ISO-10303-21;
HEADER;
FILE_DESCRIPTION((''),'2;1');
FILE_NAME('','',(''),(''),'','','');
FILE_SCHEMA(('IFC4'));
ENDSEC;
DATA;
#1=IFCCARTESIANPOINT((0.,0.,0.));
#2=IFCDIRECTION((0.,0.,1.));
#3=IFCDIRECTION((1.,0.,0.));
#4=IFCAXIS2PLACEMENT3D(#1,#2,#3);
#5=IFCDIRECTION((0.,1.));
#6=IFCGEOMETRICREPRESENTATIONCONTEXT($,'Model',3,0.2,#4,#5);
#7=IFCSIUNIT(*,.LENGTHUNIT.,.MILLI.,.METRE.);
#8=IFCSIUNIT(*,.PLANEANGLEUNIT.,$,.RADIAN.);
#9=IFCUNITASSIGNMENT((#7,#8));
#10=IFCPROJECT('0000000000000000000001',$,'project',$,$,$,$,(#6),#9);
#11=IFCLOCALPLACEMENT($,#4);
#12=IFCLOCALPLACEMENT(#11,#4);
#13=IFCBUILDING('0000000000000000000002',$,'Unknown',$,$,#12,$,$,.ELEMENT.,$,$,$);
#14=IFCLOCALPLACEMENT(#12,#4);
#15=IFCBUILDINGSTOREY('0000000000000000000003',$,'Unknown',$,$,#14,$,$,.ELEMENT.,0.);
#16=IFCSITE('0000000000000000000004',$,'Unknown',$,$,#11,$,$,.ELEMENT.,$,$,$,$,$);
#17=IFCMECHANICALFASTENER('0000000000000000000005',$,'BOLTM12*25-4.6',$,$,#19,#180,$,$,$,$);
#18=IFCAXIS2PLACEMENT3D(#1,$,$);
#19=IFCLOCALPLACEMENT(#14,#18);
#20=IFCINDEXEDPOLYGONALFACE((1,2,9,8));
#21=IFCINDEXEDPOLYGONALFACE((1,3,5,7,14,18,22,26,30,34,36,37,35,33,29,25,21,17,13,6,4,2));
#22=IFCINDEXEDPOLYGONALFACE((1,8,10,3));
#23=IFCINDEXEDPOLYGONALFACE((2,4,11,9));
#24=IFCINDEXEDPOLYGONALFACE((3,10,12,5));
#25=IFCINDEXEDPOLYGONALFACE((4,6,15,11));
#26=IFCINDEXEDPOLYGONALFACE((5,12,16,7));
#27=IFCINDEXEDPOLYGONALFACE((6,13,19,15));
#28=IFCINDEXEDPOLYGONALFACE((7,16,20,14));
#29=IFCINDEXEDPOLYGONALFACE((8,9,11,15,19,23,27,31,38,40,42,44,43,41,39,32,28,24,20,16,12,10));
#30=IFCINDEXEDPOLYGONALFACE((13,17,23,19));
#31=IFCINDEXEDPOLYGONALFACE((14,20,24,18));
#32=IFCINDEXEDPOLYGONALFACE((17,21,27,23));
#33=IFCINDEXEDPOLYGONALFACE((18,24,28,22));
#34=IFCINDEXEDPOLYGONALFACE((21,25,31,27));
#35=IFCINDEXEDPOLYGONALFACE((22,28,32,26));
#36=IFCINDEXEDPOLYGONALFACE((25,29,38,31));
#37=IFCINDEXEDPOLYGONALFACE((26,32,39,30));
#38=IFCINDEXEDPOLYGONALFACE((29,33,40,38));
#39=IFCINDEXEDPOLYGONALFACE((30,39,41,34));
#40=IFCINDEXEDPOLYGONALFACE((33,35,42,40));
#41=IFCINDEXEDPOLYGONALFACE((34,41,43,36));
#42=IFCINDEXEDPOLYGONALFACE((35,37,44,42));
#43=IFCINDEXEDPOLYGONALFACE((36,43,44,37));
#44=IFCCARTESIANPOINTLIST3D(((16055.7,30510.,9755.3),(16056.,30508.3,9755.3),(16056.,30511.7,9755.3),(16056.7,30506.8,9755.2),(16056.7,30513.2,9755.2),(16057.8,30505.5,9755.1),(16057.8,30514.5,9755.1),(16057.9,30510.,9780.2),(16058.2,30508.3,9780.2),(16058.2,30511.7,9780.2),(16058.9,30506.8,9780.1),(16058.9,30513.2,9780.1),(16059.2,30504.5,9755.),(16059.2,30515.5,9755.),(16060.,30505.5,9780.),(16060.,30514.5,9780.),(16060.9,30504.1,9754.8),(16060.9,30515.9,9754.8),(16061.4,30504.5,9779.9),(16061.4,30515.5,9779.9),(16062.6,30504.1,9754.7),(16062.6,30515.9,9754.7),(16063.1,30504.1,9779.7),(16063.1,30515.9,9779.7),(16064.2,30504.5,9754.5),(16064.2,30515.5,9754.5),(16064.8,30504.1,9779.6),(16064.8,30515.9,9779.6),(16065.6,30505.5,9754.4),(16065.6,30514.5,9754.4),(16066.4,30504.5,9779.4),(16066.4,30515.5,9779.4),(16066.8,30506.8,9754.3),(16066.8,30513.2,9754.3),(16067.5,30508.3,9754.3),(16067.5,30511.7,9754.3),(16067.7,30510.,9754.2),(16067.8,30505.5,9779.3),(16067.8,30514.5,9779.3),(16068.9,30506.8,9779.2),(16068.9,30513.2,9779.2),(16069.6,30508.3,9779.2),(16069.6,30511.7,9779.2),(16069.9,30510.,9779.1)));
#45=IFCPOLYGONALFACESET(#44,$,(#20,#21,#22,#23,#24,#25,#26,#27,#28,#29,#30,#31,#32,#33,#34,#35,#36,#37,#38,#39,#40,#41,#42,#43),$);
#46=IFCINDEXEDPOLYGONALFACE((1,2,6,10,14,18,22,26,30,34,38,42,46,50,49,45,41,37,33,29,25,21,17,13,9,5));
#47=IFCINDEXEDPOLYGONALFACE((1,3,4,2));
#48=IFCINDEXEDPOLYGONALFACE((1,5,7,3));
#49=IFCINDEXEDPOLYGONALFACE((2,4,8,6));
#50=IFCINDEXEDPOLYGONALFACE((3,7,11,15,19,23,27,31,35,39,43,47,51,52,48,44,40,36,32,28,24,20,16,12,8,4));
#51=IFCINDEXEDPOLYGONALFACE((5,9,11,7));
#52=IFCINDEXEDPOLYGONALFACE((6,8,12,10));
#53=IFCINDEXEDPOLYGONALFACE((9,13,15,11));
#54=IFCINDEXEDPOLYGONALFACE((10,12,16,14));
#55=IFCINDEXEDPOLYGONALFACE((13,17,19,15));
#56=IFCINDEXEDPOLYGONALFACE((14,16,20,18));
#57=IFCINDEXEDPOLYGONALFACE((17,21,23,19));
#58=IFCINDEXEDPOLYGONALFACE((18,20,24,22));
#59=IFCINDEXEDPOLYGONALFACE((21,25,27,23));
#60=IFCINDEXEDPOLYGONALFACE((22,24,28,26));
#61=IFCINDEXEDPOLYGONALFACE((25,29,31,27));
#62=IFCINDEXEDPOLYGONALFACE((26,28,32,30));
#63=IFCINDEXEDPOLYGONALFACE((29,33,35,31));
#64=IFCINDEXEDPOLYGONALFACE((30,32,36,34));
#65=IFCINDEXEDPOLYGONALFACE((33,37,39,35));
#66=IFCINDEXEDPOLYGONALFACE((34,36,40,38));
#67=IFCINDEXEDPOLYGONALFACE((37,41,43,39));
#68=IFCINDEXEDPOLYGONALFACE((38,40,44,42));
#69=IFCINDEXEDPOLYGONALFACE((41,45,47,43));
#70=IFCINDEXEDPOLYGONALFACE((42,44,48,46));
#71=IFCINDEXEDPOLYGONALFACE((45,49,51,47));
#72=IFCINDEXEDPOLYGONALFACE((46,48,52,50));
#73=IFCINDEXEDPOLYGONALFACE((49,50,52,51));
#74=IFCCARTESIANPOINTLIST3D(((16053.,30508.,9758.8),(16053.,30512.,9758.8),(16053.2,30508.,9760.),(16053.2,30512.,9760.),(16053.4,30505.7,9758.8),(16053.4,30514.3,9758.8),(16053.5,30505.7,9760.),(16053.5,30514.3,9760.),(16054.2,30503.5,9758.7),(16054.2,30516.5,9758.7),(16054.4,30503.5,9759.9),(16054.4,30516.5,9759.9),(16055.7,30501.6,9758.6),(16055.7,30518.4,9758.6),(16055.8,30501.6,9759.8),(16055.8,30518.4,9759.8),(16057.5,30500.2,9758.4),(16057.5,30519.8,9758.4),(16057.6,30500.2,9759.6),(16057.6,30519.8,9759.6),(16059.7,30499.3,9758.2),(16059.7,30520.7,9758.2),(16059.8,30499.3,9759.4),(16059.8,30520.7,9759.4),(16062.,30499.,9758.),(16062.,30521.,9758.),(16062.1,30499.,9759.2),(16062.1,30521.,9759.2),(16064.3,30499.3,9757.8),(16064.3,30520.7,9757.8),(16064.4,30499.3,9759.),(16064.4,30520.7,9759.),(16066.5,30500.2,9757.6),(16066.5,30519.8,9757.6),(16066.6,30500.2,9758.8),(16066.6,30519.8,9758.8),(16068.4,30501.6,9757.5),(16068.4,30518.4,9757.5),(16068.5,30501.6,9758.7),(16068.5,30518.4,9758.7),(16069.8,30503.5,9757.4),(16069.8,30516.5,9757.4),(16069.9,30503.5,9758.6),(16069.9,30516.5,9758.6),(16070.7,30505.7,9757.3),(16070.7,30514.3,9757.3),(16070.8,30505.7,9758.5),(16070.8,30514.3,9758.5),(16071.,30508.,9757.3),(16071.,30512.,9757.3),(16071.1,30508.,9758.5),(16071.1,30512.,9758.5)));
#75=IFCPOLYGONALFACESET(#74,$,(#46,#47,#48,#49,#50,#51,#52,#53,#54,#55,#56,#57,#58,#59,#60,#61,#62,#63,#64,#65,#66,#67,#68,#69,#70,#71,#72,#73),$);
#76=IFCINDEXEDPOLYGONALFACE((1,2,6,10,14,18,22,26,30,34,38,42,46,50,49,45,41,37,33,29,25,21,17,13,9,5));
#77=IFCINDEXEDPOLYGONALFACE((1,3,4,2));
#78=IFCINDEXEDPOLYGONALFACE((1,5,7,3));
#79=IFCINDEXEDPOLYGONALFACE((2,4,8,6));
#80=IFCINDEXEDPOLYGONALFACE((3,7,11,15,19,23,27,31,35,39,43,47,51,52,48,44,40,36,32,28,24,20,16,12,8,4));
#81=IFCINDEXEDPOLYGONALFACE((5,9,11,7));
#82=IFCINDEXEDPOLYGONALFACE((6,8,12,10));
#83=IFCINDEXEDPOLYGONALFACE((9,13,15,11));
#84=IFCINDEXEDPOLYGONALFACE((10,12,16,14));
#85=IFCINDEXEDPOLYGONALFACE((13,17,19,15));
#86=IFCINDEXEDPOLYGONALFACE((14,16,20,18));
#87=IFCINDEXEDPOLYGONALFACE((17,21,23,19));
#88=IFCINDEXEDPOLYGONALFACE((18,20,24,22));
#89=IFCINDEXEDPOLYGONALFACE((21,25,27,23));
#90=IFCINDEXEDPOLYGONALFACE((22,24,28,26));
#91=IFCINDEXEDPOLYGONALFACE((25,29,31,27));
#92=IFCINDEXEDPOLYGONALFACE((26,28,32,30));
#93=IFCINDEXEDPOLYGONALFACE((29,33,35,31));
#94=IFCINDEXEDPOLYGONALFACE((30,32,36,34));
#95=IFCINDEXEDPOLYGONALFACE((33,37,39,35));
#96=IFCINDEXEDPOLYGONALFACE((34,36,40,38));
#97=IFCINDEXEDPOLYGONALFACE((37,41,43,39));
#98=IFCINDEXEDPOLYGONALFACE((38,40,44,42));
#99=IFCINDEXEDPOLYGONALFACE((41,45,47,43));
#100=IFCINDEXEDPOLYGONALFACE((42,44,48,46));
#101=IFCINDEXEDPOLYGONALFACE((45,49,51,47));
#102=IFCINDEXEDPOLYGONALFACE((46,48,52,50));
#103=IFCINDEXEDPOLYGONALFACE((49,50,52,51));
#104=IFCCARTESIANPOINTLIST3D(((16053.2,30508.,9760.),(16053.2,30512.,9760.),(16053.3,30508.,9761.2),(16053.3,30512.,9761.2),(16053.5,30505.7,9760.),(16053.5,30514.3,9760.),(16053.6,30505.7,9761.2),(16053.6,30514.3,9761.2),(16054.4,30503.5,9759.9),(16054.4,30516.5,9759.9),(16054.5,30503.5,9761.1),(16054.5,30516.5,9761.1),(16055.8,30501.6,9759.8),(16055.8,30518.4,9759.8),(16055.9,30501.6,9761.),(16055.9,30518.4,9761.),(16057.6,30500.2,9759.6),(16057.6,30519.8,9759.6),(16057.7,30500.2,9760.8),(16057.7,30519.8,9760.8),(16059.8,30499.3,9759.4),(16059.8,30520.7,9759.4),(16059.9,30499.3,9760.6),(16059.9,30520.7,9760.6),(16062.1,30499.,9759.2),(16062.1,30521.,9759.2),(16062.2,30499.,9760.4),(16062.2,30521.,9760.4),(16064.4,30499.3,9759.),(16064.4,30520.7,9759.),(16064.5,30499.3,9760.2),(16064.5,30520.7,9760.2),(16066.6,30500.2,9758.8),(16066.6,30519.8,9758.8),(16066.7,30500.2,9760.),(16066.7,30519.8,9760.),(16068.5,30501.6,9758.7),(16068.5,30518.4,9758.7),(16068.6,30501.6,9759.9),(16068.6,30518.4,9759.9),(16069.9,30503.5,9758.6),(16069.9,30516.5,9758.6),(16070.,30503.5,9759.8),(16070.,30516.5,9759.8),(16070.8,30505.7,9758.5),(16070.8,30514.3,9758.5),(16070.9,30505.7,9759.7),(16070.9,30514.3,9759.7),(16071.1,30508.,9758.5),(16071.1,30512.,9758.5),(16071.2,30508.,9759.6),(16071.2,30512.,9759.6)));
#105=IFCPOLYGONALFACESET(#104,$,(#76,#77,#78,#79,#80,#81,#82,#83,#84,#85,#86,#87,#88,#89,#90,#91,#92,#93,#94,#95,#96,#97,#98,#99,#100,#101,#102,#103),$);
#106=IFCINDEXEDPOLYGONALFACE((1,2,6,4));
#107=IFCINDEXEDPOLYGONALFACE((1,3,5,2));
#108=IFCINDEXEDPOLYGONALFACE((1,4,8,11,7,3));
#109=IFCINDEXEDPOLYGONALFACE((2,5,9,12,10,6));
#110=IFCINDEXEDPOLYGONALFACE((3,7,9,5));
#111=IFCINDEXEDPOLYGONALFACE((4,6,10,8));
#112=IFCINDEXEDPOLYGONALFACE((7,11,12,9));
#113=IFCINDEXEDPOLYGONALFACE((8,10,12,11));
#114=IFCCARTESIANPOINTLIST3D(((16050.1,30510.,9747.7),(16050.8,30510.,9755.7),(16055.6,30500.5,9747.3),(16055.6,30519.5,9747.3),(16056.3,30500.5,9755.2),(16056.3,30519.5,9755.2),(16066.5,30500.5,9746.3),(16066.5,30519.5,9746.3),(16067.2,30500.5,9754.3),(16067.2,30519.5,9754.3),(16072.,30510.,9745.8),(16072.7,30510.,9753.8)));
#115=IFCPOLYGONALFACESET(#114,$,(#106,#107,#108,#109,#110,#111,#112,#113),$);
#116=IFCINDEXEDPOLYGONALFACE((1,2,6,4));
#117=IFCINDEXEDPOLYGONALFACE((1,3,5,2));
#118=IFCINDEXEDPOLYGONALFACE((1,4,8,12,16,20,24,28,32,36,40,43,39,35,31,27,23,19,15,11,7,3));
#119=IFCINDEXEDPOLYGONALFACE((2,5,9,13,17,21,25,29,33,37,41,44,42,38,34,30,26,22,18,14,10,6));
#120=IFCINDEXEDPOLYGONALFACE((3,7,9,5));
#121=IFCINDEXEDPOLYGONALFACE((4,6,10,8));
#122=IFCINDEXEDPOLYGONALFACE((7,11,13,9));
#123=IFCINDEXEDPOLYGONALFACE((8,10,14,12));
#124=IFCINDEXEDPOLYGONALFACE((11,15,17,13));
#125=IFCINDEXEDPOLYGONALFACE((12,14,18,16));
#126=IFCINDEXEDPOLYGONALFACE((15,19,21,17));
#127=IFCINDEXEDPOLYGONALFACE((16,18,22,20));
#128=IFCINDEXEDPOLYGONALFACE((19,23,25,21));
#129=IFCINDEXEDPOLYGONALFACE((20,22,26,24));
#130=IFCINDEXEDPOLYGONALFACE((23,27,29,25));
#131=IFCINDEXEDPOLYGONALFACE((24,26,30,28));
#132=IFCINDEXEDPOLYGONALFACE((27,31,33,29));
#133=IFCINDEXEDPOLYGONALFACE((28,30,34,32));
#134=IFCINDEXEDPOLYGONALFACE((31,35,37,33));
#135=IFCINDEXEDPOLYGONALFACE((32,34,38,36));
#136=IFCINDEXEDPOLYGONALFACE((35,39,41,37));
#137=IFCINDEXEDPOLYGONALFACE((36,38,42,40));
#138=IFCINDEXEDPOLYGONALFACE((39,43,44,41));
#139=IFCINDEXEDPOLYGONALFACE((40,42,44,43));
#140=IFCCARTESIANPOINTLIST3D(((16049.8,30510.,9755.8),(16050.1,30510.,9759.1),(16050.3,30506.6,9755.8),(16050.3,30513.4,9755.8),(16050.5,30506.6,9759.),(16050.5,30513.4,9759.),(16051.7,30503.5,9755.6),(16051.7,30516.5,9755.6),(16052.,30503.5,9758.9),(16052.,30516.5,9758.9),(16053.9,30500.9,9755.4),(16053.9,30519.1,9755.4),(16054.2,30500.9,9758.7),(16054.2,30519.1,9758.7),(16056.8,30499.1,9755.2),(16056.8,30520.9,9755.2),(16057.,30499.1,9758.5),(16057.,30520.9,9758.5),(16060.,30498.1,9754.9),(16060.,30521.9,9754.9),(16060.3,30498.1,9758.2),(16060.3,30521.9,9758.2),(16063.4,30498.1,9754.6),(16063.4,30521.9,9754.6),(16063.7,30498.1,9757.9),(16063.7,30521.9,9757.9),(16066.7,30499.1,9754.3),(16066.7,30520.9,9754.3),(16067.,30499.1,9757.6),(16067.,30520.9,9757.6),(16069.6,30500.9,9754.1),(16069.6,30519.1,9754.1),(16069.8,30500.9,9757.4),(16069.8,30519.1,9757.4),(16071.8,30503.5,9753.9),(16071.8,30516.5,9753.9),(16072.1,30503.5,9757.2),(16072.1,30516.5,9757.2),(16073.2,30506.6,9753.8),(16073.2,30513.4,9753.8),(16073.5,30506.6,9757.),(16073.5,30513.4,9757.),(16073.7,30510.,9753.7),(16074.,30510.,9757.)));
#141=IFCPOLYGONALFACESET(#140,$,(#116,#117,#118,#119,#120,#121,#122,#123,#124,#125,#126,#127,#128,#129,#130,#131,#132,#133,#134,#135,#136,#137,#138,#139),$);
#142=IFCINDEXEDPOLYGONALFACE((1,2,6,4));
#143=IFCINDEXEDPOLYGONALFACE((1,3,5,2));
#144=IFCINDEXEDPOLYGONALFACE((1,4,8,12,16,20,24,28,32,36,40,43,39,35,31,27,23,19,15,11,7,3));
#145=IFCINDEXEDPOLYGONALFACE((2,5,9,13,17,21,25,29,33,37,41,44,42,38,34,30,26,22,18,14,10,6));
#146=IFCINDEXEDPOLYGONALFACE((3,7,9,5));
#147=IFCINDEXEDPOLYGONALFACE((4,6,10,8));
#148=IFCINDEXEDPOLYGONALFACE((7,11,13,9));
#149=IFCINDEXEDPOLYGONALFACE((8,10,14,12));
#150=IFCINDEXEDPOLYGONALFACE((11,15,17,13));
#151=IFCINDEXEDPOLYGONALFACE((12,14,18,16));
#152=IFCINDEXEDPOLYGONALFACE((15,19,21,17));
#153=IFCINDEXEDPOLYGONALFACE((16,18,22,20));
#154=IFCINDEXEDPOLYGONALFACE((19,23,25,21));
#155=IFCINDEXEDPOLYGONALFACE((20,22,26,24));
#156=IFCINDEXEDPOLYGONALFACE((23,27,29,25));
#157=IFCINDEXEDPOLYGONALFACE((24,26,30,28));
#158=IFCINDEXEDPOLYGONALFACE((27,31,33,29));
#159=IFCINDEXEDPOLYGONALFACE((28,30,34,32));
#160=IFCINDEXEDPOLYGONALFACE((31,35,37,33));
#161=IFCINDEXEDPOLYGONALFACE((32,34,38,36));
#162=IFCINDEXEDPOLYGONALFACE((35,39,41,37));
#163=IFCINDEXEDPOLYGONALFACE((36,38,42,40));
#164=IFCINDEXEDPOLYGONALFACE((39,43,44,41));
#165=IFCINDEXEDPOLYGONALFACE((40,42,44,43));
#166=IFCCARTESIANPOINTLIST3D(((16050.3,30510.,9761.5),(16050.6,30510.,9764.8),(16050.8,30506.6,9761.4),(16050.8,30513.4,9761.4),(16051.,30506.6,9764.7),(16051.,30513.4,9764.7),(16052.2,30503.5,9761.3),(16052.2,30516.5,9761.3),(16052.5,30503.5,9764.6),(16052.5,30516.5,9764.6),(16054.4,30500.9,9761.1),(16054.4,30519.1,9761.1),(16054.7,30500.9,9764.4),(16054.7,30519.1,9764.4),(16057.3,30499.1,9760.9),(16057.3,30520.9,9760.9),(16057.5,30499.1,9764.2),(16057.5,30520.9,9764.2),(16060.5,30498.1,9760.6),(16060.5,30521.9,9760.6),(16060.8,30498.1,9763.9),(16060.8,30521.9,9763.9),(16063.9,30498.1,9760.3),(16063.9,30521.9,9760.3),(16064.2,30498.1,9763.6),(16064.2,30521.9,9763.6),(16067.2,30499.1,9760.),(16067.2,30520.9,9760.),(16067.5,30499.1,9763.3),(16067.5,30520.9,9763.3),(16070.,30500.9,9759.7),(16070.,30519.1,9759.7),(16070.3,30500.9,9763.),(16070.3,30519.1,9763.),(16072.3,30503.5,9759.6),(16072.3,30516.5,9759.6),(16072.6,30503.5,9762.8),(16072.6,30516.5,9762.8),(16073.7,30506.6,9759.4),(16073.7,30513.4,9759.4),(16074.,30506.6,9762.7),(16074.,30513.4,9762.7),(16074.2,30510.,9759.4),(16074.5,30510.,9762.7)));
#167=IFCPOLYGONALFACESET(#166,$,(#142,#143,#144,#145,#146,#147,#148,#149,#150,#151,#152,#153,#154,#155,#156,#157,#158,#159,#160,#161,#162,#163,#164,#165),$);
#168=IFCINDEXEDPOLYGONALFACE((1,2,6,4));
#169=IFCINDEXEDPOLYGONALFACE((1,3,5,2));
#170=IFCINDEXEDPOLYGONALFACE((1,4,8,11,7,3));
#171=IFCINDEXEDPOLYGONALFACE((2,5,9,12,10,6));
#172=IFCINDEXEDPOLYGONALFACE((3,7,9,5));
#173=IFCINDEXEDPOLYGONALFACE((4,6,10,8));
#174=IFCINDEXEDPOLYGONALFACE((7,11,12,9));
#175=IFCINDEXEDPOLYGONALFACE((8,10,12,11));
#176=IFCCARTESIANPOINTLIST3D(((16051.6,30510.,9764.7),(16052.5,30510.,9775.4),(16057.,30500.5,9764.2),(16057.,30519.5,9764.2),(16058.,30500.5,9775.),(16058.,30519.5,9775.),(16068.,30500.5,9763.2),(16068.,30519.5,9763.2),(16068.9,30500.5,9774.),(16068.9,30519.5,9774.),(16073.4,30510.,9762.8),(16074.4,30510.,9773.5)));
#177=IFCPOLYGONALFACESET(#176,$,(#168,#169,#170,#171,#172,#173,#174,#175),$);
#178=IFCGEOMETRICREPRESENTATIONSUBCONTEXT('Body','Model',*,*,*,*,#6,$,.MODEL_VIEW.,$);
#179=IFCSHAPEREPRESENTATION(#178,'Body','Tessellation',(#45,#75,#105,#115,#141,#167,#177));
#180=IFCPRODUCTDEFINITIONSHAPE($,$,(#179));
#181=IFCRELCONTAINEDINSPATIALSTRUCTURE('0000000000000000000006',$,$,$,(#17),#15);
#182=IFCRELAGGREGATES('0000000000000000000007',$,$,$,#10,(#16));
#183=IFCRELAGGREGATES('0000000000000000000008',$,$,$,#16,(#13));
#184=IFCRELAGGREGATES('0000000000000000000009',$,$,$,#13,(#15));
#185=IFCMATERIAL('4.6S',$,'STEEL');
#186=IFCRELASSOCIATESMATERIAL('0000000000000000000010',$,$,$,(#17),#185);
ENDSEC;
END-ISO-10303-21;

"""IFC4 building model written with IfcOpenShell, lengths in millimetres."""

from ifc_helpers import new_model, si_unit, direction, frame, origin_with_axes, place, context, subcontext, project, spatial, line, arc, indexed_curve, outline, extrude, source, transform, mapped, material, element, save


model = new_model("IFC4")

# Units and contexts
model_context = context("Model", 3, precision=0.2, world=origin_with_axes(), true_north=direction((0.0, 1.0)))
body_context = subcontext(model_context, "Body", "Model", "MODEL_VIEW")
ifc_project = project(units=[si_unit("LENGTHUNIT", "METRE", prefix="MILLI"), si_unit("PLANEANGLEUNIT", "RADIAN")], contexts=[model_context])

# Site, building, storey
site_placement = place(None, origin_with_axes())
site = spatial("IfcSite", under=ifc_project, at=site_placement, Name="Unknown", CompositionType="ELEMENT")
building_placement = place(site_placement, origin_with_axes())
building = spatial("IfcBuilding", under=site, at=building_placement, Name="Unknown", CompositionType="ELEMENT")
storey_placement = place(building_placement, origin_with_axes())
storey = spatial("IfcBuildingStorey", under=building, at=storey_placement, Name="Unknown", CompositionType="ELEMENT", Elevation=0.0)

# Mechanical fastener
ifc_material_1 = material(Name="4.6S", Category="STEEL")
shared_shape_1 = source(origin_with_axes(), body_context, "Body", "SweptSolid", [
    extrude(outline(indexed_curve([(6.0, 0.0), (0.0, 6.0), (-6.0, 0.0), (0.0, -6.0)], segments=[arc(1, 2, 3), arc(3, 4, 1)])), frame((0.0, 0.0, 4.8), z_axis=(0.0, 0.0, -1.0), x_axis=(0.0, 1.0, 0.0)), (0.0, 0.0, 1.0), 25.0),
    extrude(outline(indexed_curve([(0.0, 11.0), (6.4, 8.4), (9.0, 2.0), (9.0, -2.0), (6.4, -8.4), (0.0, -11.0), (-0.8, -11.0), (-9.0, -2.0), (-9.0, 2.0), (-6.4, 8.4)], segments=[arc(1, 2, 3), line(3, 4), arc(4, 5, 6), arc(6, 7, 8), line(8, 9), arc(9, 10, 1)])), frame((0.0, 0.0, 1.5), z_axis=(0.0, 0.0, -1.0), x_axis=(0.0, 1.0, 0.0)), (0.0, 0.0, 1.0), 1.2),
    extrude(outline(indexed_curve([(0.0, 11.0), (6.4, 8.4), (9.0, 2.0), (9.0, -2.0), (6.4, -8.4), (0.0, -11.0), (-0.8, -11.0), (-9.0, -2.0), (-9.0, 2.0), (-6.4, 8.4)], segments=[arc(1, 2, 3), line(3, 4), arc(4, 5, 6), arc(6, 7, 8), line(8, 9), arc(9, 10, 1)])), frame((0.0, 0.0, 0.3), z_axis=(0.0, 0.0, -1.0), x_axis=(0.0, 1.0, 0.0)), (0.0, 0.0, 1.0), 1.2),
    extrude(outline(indexed_curve([(11.0, 0.0), (5.5, 9.5), (-5.5, 9.5), (-11.0, 0.0), (-5.5, -9.5), (5.5, -9.5)], segments=[line(1, 2, 3, 4, 5, 6, 1)])), frame((0.0, 0.0, 12.8), z_axis=(0.0, 0.0, -1.0), x_axis=(0.0, 1.0, 0.0)), (0.0, 0.0, 1.0), 8.0),
    extrude(outline(indexed_curve([(12.0, 0.0), (0.0, 12.0), (-12.0, 0.0), (0.0, -12.0)], segments=[arc(1, 2, 3), arc(3, 4, 1)])), frame((0.0, 0.0, 4.8), z_axis=(0.0, 0.0, -1.0), x_axis=(0.0, 1.0, 0.0)), (0.0, 0.0, 1.0), 3.3),
    extrude(outline(indexed_curve([(12.0, 0.0), (0.0, 12.0), (-12.0, 0.0), (0.0, -12.0)], segments=[arc(1, 2, 3), arc(3, 4, 1)])), frame((0.0, 0.0, -0.9), z_axis=(0.0, 0.0, -1.0), x_axis=(0.0, 1.0, 0.0)), (0.0, 0.0, 1.0), 3.3),
    extrude(outline(indexed_curve([(11.0, 0.0), (5.5, 9.5), (-5.5, 9.5), (-11.0, 0.0), (-5.5, -9.5), (5.5, -9.5)], segments=[line(1, 2, 3, 4, 5, 6, 1)])), frame((0.0, 0.0, -4.2), z_axis=(0.0, 0.0, -1.0), x_axis=(0.0, 1.0, 0.0)), (0.0, 0.0, 1.0), 10.8),
])
for number, where, z_axis, x_axis, name in (
    (1, (16062.1, 30510.0, 9759.5), (-0.08716, 0.0, -0.996194), (0.0, 1.0, 0.0), "BOLTM12*25-4.6"),
):
    element("IfcMechanicalFastener", number, at=place(storey_placement, frame(where, z_axis=z_axis, x_axis=x_axis)), inside=storey, material=ifc_material_1, Name=name, context=body_context, shape_type="MappedRepresentation", body=[
        mapped(shared_shape_1, transform((0.0, 0.0, 0.0))),
    ])

save(model, "model.ifc")
